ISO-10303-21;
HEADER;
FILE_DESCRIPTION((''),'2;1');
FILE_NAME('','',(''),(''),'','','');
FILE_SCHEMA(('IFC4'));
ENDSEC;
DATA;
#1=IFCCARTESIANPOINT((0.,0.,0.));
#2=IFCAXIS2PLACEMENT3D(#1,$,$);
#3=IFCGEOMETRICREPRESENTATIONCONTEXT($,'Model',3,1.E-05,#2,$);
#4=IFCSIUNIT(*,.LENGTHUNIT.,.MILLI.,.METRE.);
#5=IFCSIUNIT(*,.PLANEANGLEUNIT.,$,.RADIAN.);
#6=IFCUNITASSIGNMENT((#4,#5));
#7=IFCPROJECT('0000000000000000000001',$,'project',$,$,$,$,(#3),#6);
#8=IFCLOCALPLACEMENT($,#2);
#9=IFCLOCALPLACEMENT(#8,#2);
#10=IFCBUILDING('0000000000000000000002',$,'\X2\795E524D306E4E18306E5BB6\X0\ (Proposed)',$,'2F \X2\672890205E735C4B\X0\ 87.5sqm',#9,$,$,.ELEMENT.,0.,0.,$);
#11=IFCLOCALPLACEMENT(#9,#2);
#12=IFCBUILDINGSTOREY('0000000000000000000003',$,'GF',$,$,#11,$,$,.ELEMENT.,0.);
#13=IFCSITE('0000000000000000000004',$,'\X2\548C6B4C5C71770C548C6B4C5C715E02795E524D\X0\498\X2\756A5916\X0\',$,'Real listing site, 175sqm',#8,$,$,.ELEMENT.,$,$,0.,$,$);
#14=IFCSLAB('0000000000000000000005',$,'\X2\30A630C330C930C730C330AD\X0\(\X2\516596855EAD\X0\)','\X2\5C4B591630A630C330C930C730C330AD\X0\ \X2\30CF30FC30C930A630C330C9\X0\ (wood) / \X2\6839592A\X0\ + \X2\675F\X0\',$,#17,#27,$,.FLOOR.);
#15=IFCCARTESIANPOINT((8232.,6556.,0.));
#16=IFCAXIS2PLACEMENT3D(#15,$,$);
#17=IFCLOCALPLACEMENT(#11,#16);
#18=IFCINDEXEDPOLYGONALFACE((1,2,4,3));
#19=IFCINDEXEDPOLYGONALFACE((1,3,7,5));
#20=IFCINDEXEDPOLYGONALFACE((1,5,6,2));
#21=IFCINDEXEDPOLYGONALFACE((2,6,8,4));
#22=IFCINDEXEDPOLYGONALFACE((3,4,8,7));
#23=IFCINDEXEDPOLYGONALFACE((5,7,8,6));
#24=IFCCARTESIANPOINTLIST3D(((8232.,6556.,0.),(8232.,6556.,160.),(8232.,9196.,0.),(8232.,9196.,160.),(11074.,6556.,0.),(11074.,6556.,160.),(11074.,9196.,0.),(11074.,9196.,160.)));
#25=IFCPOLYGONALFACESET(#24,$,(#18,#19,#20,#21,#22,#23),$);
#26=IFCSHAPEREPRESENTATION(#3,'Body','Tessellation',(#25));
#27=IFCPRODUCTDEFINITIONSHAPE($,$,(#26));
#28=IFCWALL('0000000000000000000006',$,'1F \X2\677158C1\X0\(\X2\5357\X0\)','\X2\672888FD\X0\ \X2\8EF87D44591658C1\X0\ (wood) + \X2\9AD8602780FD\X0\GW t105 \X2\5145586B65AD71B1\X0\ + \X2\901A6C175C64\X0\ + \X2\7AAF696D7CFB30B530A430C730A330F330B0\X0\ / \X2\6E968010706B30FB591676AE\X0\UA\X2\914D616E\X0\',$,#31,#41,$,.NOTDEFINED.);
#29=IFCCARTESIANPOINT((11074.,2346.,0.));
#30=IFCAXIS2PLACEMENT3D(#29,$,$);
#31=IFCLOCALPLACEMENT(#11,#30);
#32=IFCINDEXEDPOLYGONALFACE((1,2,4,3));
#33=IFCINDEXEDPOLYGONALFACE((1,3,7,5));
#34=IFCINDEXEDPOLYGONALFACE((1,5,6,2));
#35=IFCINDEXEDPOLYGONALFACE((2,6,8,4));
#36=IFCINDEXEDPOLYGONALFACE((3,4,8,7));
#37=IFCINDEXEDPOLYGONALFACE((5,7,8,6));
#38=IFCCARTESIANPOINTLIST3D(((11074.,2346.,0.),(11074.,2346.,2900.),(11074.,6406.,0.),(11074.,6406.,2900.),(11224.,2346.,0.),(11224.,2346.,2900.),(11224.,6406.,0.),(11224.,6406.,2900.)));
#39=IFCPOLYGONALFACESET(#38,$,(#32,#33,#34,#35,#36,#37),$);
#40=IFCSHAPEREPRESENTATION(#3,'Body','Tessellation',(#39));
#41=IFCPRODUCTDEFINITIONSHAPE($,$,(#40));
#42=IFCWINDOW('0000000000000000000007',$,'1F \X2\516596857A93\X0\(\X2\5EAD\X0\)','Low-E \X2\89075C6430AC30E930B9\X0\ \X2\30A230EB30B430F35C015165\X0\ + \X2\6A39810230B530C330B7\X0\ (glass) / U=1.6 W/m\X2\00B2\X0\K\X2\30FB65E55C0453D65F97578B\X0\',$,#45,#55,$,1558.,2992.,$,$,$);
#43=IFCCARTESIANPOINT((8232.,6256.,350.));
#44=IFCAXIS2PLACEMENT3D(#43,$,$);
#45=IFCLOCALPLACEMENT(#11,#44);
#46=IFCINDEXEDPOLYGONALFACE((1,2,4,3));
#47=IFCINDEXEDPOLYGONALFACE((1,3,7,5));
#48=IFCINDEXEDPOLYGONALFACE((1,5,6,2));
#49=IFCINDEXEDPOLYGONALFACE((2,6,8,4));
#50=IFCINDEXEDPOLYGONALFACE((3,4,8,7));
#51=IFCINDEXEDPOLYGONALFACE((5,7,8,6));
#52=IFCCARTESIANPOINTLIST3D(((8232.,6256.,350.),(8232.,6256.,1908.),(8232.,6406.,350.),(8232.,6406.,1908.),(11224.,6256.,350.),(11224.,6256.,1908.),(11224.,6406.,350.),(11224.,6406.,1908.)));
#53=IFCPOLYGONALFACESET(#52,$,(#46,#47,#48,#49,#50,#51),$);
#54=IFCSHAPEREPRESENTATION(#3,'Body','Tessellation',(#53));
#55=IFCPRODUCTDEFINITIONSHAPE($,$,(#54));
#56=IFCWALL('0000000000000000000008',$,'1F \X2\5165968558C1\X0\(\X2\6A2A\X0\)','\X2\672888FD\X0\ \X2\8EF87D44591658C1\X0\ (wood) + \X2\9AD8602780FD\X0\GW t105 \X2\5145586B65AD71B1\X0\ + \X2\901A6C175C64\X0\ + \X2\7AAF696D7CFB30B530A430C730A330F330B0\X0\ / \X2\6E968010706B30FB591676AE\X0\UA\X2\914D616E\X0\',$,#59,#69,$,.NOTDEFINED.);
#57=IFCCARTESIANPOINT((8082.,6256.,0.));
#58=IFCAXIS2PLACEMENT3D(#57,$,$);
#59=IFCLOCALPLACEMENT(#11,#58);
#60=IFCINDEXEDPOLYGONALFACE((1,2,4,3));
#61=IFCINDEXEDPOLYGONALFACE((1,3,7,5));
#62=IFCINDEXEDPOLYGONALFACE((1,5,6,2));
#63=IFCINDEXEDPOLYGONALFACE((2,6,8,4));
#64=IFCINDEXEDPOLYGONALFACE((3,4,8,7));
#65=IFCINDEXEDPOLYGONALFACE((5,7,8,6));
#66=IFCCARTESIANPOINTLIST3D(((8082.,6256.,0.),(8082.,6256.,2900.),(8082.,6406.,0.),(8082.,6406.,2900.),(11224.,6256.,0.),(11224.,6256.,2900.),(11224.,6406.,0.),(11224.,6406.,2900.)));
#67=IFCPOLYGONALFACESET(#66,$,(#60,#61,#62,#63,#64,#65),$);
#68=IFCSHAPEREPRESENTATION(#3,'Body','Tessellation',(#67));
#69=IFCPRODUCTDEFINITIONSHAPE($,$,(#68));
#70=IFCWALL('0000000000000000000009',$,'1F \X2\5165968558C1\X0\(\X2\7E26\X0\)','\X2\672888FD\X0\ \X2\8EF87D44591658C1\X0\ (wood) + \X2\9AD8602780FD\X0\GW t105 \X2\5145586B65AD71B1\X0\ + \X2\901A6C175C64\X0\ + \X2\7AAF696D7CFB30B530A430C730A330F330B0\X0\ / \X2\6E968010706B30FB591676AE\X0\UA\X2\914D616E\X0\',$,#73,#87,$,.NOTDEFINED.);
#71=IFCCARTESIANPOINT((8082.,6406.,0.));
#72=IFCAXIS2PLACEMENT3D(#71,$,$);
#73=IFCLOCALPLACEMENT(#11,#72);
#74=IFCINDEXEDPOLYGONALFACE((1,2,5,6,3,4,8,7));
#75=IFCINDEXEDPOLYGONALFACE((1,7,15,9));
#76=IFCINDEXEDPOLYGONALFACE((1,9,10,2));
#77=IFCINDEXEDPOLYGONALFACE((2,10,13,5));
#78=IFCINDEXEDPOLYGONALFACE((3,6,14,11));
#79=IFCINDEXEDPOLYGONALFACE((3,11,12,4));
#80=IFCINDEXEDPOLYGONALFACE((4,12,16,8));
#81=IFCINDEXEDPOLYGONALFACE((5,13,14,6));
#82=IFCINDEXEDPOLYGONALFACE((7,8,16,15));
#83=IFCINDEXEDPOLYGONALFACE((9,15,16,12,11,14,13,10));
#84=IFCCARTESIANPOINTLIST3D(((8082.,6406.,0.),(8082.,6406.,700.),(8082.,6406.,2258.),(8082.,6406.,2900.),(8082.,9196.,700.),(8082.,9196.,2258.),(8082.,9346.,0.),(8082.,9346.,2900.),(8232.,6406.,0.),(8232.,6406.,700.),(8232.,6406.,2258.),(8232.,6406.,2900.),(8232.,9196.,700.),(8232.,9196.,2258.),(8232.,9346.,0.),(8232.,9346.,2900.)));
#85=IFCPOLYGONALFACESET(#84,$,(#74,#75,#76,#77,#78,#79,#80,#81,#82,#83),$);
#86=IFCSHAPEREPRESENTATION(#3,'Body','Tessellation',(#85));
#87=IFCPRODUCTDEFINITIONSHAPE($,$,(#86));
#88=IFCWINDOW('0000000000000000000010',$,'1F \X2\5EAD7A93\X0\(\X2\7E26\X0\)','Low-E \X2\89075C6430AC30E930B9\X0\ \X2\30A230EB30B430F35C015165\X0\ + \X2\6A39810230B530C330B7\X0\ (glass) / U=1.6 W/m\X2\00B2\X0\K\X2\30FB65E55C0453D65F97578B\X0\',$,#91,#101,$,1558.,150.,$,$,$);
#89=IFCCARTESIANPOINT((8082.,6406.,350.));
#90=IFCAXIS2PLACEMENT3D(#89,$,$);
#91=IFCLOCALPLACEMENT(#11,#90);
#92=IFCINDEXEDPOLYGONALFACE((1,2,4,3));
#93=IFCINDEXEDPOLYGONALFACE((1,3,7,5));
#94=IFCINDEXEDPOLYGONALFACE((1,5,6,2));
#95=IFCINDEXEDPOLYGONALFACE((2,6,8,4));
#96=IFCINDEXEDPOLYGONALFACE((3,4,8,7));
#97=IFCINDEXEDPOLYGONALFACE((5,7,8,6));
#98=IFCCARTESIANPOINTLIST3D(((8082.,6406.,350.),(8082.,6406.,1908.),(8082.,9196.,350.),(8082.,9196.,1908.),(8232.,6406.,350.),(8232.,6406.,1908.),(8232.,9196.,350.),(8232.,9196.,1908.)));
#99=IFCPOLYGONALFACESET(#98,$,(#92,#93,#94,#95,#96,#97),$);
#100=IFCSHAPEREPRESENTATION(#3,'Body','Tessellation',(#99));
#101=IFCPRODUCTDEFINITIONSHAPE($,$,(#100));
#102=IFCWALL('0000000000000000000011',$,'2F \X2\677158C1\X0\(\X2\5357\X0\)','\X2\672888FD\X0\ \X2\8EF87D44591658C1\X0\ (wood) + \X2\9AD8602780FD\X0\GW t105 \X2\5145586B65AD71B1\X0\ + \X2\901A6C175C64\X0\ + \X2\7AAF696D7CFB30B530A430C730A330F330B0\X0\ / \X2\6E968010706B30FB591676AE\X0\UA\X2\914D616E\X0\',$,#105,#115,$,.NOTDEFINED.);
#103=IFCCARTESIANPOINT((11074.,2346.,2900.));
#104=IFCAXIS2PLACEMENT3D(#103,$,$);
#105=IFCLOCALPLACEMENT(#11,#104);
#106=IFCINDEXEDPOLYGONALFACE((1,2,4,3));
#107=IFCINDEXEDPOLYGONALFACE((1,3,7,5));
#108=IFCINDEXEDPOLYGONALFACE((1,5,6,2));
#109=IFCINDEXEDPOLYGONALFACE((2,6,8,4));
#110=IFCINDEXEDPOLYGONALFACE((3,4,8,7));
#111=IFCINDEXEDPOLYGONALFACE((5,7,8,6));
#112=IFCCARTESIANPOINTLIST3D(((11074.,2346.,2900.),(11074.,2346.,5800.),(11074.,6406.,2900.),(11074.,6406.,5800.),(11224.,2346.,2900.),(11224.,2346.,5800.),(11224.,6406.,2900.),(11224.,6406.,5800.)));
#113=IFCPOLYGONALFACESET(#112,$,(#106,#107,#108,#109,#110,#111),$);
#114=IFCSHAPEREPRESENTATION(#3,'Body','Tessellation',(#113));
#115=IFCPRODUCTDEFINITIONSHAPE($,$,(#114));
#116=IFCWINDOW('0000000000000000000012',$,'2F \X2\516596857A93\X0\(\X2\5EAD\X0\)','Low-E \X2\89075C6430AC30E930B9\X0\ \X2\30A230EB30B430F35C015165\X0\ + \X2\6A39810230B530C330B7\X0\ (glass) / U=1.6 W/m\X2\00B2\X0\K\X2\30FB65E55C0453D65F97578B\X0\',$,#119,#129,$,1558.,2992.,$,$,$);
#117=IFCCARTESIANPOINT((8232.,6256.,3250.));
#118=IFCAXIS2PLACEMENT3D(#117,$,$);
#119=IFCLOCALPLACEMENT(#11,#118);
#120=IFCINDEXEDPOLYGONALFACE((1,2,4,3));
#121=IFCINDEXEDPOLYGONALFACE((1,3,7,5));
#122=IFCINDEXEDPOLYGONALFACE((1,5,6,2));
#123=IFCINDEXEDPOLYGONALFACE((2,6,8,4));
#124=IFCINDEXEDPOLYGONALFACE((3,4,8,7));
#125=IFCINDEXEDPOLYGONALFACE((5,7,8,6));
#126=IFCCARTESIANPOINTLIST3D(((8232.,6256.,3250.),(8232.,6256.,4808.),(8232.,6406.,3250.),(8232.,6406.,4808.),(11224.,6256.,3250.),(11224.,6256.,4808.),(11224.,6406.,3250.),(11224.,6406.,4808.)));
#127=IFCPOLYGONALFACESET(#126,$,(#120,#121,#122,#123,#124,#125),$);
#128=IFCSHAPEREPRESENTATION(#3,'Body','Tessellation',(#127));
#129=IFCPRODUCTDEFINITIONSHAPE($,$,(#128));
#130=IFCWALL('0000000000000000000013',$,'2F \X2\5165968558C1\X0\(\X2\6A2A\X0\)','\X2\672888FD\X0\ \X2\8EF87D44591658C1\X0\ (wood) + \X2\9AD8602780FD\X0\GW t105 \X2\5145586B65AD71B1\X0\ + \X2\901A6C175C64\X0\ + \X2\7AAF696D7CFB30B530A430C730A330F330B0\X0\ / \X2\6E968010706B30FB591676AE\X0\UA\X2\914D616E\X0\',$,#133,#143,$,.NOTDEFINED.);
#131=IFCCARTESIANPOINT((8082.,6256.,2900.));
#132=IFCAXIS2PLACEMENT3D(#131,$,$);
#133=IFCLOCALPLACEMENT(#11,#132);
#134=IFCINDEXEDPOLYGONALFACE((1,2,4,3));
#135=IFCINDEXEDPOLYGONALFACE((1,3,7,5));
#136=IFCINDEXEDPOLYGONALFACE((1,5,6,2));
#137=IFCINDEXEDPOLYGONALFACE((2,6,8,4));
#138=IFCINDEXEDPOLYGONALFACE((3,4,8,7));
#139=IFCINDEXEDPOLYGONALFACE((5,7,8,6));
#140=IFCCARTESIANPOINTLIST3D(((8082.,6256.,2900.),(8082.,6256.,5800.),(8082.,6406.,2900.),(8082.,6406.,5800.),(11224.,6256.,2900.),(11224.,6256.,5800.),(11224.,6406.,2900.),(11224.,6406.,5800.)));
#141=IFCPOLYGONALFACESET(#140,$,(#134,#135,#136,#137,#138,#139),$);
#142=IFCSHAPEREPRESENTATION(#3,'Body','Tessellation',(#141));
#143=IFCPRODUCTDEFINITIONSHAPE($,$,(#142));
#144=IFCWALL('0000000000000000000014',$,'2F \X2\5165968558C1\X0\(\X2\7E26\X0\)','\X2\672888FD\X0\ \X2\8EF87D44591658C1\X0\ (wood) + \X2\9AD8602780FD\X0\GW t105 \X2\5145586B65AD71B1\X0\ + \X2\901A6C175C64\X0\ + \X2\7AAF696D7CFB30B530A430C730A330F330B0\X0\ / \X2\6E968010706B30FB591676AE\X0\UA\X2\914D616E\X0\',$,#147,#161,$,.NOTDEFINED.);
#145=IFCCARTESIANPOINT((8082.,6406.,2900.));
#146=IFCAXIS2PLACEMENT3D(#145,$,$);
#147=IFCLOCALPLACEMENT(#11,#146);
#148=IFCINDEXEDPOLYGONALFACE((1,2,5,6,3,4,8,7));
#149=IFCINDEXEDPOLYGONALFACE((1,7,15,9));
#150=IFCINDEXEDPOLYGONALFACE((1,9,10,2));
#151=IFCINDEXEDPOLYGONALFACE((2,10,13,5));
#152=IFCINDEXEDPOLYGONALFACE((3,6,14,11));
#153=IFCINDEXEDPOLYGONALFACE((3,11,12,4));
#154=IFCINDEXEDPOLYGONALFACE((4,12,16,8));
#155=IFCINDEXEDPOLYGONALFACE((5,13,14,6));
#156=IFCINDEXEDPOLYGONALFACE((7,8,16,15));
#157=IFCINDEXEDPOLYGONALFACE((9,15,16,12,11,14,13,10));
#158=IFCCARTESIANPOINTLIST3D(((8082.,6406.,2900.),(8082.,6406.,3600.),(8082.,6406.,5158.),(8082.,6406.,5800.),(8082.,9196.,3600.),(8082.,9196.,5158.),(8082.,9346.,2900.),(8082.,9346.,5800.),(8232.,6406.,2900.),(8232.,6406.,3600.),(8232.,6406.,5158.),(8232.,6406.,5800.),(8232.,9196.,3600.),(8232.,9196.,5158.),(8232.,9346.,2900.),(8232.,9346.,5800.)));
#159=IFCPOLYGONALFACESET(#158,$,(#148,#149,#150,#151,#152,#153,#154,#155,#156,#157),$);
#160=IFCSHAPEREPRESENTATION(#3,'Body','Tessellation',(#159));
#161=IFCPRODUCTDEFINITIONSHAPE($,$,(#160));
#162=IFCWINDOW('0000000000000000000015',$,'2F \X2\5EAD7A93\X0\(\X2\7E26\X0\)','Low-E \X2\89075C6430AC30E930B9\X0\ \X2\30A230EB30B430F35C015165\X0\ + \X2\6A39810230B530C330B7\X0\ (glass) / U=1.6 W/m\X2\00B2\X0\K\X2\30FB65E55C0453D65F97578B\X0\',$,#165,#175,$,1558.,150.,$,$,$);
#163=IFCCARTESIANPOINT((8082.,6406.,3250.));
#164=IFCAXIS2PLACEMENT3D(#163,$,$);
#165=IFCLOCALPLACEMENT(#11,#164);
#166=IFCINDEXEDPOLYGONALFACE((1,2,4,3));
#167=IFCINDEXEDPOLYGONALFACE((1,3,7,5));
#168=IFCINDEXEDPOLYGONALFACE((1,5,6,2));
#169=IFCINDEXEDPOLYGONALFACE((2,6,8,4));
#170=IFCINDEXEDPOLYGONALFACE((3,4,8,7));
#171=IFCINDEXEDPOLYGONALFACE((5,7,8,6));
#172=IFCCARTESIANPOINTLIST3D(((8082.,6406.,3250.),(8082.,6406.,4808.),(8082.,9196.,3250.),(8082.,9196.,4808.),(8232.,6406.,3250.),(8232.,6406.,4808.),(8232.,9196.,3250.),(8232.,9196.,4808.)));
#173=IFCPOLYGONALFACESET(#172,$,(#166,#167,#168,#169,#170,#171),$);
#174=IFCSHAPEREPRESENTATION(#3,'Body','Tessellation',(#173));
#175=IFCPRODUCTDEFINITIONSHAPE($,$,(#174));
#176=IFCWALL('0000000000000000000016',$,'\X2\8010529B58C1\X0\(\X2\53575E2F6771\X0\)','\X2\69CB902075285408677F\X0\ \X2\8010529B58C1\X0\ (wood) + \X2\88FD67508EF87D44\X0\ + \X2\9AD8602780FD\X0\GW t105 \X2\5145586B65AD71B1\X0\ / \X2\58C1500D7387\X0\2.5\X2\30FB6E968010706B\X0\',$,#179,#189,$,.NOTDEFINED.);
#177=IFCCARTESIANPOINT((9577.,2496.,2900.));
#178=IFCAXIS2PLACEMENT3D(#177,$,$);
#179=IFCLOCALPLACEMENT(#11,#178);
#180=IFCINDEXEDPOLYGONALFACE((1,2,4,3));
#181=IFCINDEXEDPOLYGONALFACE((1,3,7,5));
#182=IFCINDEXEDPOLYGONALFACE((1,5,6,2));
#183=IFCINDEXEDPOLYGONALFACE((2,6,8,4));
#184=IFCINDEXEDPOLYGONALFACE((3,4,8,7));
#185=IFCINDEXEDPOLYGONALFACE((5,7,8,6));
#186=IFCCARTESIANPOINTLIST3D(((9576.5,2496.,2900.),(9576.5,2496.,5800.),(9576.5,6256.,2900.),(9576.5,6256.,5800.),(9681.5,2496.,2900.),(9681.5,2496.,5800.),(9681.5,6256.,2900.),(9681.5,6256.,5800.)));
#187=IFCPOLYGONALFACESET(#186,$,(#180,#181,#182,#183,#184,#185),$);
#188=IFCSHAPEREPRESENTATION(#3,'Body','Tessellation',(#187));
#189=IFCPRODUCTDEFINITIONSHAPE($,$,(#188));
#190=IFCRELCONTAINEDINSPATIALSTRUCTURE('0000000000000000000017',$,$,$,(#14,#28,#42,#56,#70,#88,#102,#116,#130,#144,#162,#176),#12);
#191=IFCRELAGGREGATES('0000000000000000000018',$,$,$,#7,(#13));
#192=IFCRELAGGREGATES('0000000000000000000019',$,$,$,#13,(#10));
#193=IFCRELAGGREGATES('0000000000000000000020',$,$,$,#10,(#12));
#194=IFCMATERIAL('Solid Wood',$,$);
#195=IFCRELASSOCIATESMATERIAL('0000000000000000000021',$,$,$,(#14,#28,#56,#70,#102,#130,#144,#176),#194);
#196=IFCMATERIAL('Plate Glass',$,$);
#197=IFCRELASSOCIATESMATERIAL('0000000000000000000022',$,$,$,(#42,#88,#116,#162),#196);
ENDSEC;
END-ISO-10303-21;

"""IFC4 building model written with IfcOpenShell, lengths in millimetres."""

from ifc_helpers import new_model, si_unit, frame, frame_2d, origin, place, context, project, spatial, rectangle, extrude, material, element, fill, save


model = new_model("IFC4")

# Units and contexts
model_context = context("Model", 3, precision=1e-05, world=origin())
ifc_project = project(units=[si_unit("LENGTHUNIT", "METRE", prefix="MILLI"), si_unit("PLANEANGLEUNIT", "RADIAN")], contexts=[model_context])

# Site, building, storey
site_placement = place(None, origin())
site = spatial("IfcSite", under=ifc_project, at=site_placement, Name="和歌山県和歌山市神前498番外", ObjectType="Real listing site, 175sqm", CompositionType="ELEMENT", RefElevation=0.0)
building_placement = place(site_placement, origin())
building = spatial("IfcBuilding", under=site, at=building_placement, Name="神前の丘の家 (Proposed)", ObjectType="2F 木造平屋 87.5sqm", CompositionType="ELEMENT", ElevationOfRefHeight=0.0, ElevationOfTerrain=0.0)
storey_placement = place(building_placement, origin())
storey = spatial("IfcBuildingStorey", under=building, at=storey_placement, Name="GF", CompositionType="ELEMENT", Elevation=0.0)

# Slab
ifc_material_1 = material(Name="Solid Wood")
slab_placement = place(storey_placement, frame((8232.0, 6556.0, 0.0)))
element("IfcSlab", 1, at=slab_placement, inside=storey, material=ifc_material_1, Name="ウッドデッキ(入隅庭)", Description="屋外ウッドデッキ ハードウッド (wood) / 根太 + 束", PredefinedType="FLOOR", context=model_context, shape_type="SweptSolid", body=[
    extrude(rectangle(XDim=2842.0, YDim=2640.0, at=frame_2d((1421.0, 1320.0))), frame((8232.0, 6556.0, 0.0)), (0.0, 0.0, 1.0), 160.0),
])

# Wall, opening, window
wall_1_placement = place(storey_placement, frame((11074.0, 2346.0, 0.0)))
wall_1 = element("IfcWall", 2, at=wall_1_placement, inside=storey, material=ifc_material_1, Name="1F 東壁(南)", Description="木製 軸組外壁 (wood) + 高性能GW t105 充填断熱 + 通気層 + 窯業系サイディング / 準耐火・外皮UA配慮", PredefinedType="NOTDEFINED", context=model_context, shape_type="SweptSolid", body=[
    extrude(rectangle(XDim=150.0, YDim=4060.0, at=frame_2d((75.0, 2030.0))), frame((11074.0, 2346.0, 0.0)), (0.0, 0.0, 1.0), 2900.0),
])
opening_1_placement = place(storey_placement, frame((8232.0, 6256.0, 350.0)))
opening_1 = element("IfcOpeningElement", 3, at=opening_1_placement, cuts=wall_1, PredefinedType="NOTDEFINED", context=model_context, shape_type="SweptSolid", body=[
    extrude(rectangle(XDim=2992.0, YDim=150.0, at=frame_2d((1496.0, 75.0))), frame((8232.0, 6256.0, 350.0)), (0.0, 0.0, 1.0), 1558.0),
])
ifc_material_2 = material(Name="Plate Glass")
window_1_placement = place(storey_placement, frame((8232.0, 6256.0, 350.0)))
window_1 = element("IfcWindow", 4, at=window_1_placement, inside=storey, material=ifc_material_2, Name="1F 入隅窓(庭)", Description="Low-E 複層ガラス アルゴン封入 + 樹脂サッシ (glass) / U=1.6 W/m²K・日射取得型", OverallHeight=1558.0, OverallWidth=2992.0, context=model_context, shape_type="SweptSolid", body=[
    extrude(rectangle(XDim=2992.0, YDim=150.0, at=frame_2d((1496.0, 75.0))), frame((8232.0, 6256.0, 350.0)), (0.0, 0.0, 1.0), 1558.0),
])
fill(opening_1, window_1)

# Wall
wall_2_placement = place(storey_placement, frame((8082.0, 6256.0, 0.0)))
element("IfcWall", 5, at=wall_2_placement, inside=storey, material=ifc_material_1, Name="1F 入隅壁(横)", Description="木製 軸組外壁 (wood) + 高性能GW t105 充填断熱 + 通気層 + 窯業系サイディング / 準耐火・外皮UA配慮", PredefinedType="NOTDEFINED", context=model_context, shape_type="SweptSolid", body=[
    extrude(rectangle(XDim=3142.0, YDim=150.0, at=frame_2d((1571.0, 75.0))), frame((8082.0, 6256.0, 0.0)), (0.0, 0.0, 1.0), 2900.0),
])

# Wall, opening, window
wall_3_placement = place(storey_placement, frame((8082.0, 6406.0, 0.0)))
wall_3 = element("IfcWall", 6, at=wall_3_placement, inside=storey, material=ifc_material_1, Name="1F 入隅壁(縦)", Description="木製 軸組外壁 (wood) + 高性能GW t105 充填断熱 + 通気層 + 窯業系サイディング / 準耐火・外皮UA配慮", PredefinedType="NOTDEFINED", context=model_context, shape_type="SweptSolid", body=[
    extrude(rectangle(XDim=150.0, YDim=2940.0, at=frame_2d((75.0, 1470.0))), frame((8082.0, 6406.0, 0.0)), (0.0, 0.0, 1.0), 2900.0),
])
opening_2_placement = place(storey_placement, frame((8082.0, 6406.0, 350.0)))
opening_2 = element("IfcOpeningElement", 7, at=opening_2_placement, cuts=wall_3, PredefinedType="NOTDEFINED", context=model_context, shape_type="SweptSolid", body=[
    extrude(rectangle(XDim=150.0, YDim=2790.0, at=frame_2d((75.0, 1395.0))), frame((8082.0, 6406.0, 350.0)), (0.0, 0.0, 1.0), 1558.0),
])
window_2_placement = place(storey_placement, frame((8082.0, 6406.0, 350.0)))
window_2 = element("IfcWindow", 8, at=window_2_placement, inside=storey, material=ifc_material_2, Name="1F 庭窓(縦)", Description="Low-E 複層ガラス アルゴン封入 + 樹脂サッシ (glass) / U=1.6 W/m²K・日射取得型", OverallHeight=1558.0, OverallWidth=150.0, context=model_context, shape_type="SweptSolid", body=[
    extrude(rectangle(XDim=150.0, YDim=2790.0, at=frame_2d((75.0, 1395.0))), frame((8082.0, 6406.0, 350.0)), (0.0, 0.0, 1.0), 1558.0),
])
fill(opening_2, window_2)

# Wall, opening, window
wall_4_placement = place(storey_placement, frame((11074.0, 2346.0, 2900.0)))
wall_4 = element("IfcWall", 9, at=wall_4_placement, inside=storey, material=ifc_material_1, Name="2F 東壁(南)", Description="木製 軸組外壁 (wood) + 高性能GW t105 充填断熱 + 通気層 + 窯業系サイディング / 準耐火・外皮UA配慮", PredefinedType="NOTDEFINED", context=model_context, shape_type="SweptSolid", body=[
    extrude(rectangle(XDim=150.0, YDim=4060.0, at=frame_2d((75.0, 2030.0))), frame((11074.0, 2346.0, 2900.0)), (0.0, 0.0, 1.0), 2900.0),
])
opening_3_placement = place(storey_placement, frame((8232.0, 6256.0, 3250.0)))
opening_3 = element("IfcOpeningElement", 10, at=opening_3_placement, cuts=wall_4, PredefinedType="NOTDEFINED", context=model_context, shape_type="SweptSolid", body=[
    extrude(rectangle(XDim=2992.0, YDim=150.0, at=frame_2d((1496.0, 75.0))), frame((8232.0, 6256.0, 3250.0)), (0.0, 0.0, 1.0), 1558.0),
])
window_3_placement = place(storey_placement, frame((8232.0, 6256.0, 3250.0)))
window_3 = element("IfcWindow", 11, at=window_3_placement, inside=storey, material=ifc_material_2, Name="2F 入隅窓(庭)", Description="Low-E 複層ガラス アルゴン封入 + 樹脂サッシ (glass) / U=1.6 W/m²K・日射取得型", OverallHeight=1558.0, OverallWidth=2992.0, context=model_context, shape_type="SweptSolid", body=[
    extrude(rectangle(XDim=2992.0, YDim=150.0, at=frame_2d((1496.0, 75.0))), frame((8232.0, 6256.0, 3250.0)), (0.0, 0.0, 1.0), 1558.0),
])
fill(opening_3, window_3)

# Wall
wall_5_placement = place(storey_placement, frame((8082.0, 6256.0, 2900.0)))
element("IfcWall", 12, at=wall_5_placement, inside=storey, material=ifc_material_1, Name="2F 入隅壁(横)", Description="木製 軸組外壁 (wood) + 高性能GW t105 充填断熱 + 通気層 + 窯業系サイディング / 準耐火・外皮UA配慮", PredefinedType="NOTDEFINED", context=model_context, shape_type="SweptSolid", body=[
    extrude(rectangle(XDim=3142.0, YDim=150.0, at=frame_2d((1571.0, 75.0))), frame((8082.0, 6256.0, 2900.0)), (0.0, 0.0, 1.0), 2900.0),
])

# Wall, opening, window
wall_6_placement = place(storey_placement, frame((8082.0, 6406.0, 2900.0)))
wall_6 = element("IfcWall", 13, at=wall_6_placement, inside=storey, material=ifc_material_1, Name="2F 入隅壁(縦)", Description="木製 軸組外壁 (wood) + 高性能GW t105 充填断熱 + 通気層 + 窯業系サイディング / 準耐火・外皮UA配慮", PredefinedType="NOTDEFINED", context=model_context, shape_type="SweptSolid", body=[
    extrude(rectangle(XDim=150.0, YDim=2940.0, at=frame_2d((75.0, 1470.0))), frame((8082.0, 6406.0, 2900.0)), (0.0, 0.0, 1.0), 2900.0),
])
opening_4_placement = place(storey_placement, frame((8082.0, 6406.0, 3250.0)))
opening_4 = element("IfcOpeningElement", 14, at=opening_4_placement, cuts=wall_6, PredefinedType="NOTDEFINED", context=model_context, shape_type="SweptSolid", body=[
    extrude(rectangle(XDim=150.0, YDim=2790.0, at=frame_2d((75.0, 1395.0))), frame((8082.0, 6406.0, 3250.0)), (0.0, 0.0, 1.0), 1558.0),
])
window_4_placement = place(storey_placement, frame((8082.0, 6406.0, 3250.0)))
window_4 = element("IfcWindow", 15, at=window_4_placement, inside=storey, material=ifc_material_2, Name="2F 庭窓(縦)", Description="Low-E 複層ガラス アルゴン封入 + 樹脂サッシ (glass) / U=1.6 W/m²K・日射取得型", OverallHeight=1558.0, OverallWidth=150.0, context=model_context, shape_type="SweptSolid", body=[
    extrude(rectangle(XDim=150.0, YDim=2790.0, at=frame_2d((75.0, 1395.0))), frame((8082.0, 6406.0, 3250.0)), (0.0, 0.0, 1.0), 1558.0),
])
fill(opening_4, window_4)

# Wall
wall_7_placement = place(storey_placement, frame((9577.0, 2496.0, 2900.0)))
element("IfcWall", 16, at=wall_7_placement, inside=storey, material=ifc_material_1, Name="耐力壁(南帯東)", Description="構造用合板 耐力壁 (wood) + 製材軸組 + 高性能GW t105 充填断熱 / 壁倍率2.5・準耐火", PredefinedType="NOTDEFINED", context=model_context, shape_type="SweptSolid", body=[
    extrude(rectangle(XDim=105.0, YDim=3760.0, at=frame_2d((52.0, 1880.0))), frame((9577.0, 2496.0, 2900.0)), (0.0, 0.0, 1.0), 2900.0),
])

save(model, "model.ifc")
